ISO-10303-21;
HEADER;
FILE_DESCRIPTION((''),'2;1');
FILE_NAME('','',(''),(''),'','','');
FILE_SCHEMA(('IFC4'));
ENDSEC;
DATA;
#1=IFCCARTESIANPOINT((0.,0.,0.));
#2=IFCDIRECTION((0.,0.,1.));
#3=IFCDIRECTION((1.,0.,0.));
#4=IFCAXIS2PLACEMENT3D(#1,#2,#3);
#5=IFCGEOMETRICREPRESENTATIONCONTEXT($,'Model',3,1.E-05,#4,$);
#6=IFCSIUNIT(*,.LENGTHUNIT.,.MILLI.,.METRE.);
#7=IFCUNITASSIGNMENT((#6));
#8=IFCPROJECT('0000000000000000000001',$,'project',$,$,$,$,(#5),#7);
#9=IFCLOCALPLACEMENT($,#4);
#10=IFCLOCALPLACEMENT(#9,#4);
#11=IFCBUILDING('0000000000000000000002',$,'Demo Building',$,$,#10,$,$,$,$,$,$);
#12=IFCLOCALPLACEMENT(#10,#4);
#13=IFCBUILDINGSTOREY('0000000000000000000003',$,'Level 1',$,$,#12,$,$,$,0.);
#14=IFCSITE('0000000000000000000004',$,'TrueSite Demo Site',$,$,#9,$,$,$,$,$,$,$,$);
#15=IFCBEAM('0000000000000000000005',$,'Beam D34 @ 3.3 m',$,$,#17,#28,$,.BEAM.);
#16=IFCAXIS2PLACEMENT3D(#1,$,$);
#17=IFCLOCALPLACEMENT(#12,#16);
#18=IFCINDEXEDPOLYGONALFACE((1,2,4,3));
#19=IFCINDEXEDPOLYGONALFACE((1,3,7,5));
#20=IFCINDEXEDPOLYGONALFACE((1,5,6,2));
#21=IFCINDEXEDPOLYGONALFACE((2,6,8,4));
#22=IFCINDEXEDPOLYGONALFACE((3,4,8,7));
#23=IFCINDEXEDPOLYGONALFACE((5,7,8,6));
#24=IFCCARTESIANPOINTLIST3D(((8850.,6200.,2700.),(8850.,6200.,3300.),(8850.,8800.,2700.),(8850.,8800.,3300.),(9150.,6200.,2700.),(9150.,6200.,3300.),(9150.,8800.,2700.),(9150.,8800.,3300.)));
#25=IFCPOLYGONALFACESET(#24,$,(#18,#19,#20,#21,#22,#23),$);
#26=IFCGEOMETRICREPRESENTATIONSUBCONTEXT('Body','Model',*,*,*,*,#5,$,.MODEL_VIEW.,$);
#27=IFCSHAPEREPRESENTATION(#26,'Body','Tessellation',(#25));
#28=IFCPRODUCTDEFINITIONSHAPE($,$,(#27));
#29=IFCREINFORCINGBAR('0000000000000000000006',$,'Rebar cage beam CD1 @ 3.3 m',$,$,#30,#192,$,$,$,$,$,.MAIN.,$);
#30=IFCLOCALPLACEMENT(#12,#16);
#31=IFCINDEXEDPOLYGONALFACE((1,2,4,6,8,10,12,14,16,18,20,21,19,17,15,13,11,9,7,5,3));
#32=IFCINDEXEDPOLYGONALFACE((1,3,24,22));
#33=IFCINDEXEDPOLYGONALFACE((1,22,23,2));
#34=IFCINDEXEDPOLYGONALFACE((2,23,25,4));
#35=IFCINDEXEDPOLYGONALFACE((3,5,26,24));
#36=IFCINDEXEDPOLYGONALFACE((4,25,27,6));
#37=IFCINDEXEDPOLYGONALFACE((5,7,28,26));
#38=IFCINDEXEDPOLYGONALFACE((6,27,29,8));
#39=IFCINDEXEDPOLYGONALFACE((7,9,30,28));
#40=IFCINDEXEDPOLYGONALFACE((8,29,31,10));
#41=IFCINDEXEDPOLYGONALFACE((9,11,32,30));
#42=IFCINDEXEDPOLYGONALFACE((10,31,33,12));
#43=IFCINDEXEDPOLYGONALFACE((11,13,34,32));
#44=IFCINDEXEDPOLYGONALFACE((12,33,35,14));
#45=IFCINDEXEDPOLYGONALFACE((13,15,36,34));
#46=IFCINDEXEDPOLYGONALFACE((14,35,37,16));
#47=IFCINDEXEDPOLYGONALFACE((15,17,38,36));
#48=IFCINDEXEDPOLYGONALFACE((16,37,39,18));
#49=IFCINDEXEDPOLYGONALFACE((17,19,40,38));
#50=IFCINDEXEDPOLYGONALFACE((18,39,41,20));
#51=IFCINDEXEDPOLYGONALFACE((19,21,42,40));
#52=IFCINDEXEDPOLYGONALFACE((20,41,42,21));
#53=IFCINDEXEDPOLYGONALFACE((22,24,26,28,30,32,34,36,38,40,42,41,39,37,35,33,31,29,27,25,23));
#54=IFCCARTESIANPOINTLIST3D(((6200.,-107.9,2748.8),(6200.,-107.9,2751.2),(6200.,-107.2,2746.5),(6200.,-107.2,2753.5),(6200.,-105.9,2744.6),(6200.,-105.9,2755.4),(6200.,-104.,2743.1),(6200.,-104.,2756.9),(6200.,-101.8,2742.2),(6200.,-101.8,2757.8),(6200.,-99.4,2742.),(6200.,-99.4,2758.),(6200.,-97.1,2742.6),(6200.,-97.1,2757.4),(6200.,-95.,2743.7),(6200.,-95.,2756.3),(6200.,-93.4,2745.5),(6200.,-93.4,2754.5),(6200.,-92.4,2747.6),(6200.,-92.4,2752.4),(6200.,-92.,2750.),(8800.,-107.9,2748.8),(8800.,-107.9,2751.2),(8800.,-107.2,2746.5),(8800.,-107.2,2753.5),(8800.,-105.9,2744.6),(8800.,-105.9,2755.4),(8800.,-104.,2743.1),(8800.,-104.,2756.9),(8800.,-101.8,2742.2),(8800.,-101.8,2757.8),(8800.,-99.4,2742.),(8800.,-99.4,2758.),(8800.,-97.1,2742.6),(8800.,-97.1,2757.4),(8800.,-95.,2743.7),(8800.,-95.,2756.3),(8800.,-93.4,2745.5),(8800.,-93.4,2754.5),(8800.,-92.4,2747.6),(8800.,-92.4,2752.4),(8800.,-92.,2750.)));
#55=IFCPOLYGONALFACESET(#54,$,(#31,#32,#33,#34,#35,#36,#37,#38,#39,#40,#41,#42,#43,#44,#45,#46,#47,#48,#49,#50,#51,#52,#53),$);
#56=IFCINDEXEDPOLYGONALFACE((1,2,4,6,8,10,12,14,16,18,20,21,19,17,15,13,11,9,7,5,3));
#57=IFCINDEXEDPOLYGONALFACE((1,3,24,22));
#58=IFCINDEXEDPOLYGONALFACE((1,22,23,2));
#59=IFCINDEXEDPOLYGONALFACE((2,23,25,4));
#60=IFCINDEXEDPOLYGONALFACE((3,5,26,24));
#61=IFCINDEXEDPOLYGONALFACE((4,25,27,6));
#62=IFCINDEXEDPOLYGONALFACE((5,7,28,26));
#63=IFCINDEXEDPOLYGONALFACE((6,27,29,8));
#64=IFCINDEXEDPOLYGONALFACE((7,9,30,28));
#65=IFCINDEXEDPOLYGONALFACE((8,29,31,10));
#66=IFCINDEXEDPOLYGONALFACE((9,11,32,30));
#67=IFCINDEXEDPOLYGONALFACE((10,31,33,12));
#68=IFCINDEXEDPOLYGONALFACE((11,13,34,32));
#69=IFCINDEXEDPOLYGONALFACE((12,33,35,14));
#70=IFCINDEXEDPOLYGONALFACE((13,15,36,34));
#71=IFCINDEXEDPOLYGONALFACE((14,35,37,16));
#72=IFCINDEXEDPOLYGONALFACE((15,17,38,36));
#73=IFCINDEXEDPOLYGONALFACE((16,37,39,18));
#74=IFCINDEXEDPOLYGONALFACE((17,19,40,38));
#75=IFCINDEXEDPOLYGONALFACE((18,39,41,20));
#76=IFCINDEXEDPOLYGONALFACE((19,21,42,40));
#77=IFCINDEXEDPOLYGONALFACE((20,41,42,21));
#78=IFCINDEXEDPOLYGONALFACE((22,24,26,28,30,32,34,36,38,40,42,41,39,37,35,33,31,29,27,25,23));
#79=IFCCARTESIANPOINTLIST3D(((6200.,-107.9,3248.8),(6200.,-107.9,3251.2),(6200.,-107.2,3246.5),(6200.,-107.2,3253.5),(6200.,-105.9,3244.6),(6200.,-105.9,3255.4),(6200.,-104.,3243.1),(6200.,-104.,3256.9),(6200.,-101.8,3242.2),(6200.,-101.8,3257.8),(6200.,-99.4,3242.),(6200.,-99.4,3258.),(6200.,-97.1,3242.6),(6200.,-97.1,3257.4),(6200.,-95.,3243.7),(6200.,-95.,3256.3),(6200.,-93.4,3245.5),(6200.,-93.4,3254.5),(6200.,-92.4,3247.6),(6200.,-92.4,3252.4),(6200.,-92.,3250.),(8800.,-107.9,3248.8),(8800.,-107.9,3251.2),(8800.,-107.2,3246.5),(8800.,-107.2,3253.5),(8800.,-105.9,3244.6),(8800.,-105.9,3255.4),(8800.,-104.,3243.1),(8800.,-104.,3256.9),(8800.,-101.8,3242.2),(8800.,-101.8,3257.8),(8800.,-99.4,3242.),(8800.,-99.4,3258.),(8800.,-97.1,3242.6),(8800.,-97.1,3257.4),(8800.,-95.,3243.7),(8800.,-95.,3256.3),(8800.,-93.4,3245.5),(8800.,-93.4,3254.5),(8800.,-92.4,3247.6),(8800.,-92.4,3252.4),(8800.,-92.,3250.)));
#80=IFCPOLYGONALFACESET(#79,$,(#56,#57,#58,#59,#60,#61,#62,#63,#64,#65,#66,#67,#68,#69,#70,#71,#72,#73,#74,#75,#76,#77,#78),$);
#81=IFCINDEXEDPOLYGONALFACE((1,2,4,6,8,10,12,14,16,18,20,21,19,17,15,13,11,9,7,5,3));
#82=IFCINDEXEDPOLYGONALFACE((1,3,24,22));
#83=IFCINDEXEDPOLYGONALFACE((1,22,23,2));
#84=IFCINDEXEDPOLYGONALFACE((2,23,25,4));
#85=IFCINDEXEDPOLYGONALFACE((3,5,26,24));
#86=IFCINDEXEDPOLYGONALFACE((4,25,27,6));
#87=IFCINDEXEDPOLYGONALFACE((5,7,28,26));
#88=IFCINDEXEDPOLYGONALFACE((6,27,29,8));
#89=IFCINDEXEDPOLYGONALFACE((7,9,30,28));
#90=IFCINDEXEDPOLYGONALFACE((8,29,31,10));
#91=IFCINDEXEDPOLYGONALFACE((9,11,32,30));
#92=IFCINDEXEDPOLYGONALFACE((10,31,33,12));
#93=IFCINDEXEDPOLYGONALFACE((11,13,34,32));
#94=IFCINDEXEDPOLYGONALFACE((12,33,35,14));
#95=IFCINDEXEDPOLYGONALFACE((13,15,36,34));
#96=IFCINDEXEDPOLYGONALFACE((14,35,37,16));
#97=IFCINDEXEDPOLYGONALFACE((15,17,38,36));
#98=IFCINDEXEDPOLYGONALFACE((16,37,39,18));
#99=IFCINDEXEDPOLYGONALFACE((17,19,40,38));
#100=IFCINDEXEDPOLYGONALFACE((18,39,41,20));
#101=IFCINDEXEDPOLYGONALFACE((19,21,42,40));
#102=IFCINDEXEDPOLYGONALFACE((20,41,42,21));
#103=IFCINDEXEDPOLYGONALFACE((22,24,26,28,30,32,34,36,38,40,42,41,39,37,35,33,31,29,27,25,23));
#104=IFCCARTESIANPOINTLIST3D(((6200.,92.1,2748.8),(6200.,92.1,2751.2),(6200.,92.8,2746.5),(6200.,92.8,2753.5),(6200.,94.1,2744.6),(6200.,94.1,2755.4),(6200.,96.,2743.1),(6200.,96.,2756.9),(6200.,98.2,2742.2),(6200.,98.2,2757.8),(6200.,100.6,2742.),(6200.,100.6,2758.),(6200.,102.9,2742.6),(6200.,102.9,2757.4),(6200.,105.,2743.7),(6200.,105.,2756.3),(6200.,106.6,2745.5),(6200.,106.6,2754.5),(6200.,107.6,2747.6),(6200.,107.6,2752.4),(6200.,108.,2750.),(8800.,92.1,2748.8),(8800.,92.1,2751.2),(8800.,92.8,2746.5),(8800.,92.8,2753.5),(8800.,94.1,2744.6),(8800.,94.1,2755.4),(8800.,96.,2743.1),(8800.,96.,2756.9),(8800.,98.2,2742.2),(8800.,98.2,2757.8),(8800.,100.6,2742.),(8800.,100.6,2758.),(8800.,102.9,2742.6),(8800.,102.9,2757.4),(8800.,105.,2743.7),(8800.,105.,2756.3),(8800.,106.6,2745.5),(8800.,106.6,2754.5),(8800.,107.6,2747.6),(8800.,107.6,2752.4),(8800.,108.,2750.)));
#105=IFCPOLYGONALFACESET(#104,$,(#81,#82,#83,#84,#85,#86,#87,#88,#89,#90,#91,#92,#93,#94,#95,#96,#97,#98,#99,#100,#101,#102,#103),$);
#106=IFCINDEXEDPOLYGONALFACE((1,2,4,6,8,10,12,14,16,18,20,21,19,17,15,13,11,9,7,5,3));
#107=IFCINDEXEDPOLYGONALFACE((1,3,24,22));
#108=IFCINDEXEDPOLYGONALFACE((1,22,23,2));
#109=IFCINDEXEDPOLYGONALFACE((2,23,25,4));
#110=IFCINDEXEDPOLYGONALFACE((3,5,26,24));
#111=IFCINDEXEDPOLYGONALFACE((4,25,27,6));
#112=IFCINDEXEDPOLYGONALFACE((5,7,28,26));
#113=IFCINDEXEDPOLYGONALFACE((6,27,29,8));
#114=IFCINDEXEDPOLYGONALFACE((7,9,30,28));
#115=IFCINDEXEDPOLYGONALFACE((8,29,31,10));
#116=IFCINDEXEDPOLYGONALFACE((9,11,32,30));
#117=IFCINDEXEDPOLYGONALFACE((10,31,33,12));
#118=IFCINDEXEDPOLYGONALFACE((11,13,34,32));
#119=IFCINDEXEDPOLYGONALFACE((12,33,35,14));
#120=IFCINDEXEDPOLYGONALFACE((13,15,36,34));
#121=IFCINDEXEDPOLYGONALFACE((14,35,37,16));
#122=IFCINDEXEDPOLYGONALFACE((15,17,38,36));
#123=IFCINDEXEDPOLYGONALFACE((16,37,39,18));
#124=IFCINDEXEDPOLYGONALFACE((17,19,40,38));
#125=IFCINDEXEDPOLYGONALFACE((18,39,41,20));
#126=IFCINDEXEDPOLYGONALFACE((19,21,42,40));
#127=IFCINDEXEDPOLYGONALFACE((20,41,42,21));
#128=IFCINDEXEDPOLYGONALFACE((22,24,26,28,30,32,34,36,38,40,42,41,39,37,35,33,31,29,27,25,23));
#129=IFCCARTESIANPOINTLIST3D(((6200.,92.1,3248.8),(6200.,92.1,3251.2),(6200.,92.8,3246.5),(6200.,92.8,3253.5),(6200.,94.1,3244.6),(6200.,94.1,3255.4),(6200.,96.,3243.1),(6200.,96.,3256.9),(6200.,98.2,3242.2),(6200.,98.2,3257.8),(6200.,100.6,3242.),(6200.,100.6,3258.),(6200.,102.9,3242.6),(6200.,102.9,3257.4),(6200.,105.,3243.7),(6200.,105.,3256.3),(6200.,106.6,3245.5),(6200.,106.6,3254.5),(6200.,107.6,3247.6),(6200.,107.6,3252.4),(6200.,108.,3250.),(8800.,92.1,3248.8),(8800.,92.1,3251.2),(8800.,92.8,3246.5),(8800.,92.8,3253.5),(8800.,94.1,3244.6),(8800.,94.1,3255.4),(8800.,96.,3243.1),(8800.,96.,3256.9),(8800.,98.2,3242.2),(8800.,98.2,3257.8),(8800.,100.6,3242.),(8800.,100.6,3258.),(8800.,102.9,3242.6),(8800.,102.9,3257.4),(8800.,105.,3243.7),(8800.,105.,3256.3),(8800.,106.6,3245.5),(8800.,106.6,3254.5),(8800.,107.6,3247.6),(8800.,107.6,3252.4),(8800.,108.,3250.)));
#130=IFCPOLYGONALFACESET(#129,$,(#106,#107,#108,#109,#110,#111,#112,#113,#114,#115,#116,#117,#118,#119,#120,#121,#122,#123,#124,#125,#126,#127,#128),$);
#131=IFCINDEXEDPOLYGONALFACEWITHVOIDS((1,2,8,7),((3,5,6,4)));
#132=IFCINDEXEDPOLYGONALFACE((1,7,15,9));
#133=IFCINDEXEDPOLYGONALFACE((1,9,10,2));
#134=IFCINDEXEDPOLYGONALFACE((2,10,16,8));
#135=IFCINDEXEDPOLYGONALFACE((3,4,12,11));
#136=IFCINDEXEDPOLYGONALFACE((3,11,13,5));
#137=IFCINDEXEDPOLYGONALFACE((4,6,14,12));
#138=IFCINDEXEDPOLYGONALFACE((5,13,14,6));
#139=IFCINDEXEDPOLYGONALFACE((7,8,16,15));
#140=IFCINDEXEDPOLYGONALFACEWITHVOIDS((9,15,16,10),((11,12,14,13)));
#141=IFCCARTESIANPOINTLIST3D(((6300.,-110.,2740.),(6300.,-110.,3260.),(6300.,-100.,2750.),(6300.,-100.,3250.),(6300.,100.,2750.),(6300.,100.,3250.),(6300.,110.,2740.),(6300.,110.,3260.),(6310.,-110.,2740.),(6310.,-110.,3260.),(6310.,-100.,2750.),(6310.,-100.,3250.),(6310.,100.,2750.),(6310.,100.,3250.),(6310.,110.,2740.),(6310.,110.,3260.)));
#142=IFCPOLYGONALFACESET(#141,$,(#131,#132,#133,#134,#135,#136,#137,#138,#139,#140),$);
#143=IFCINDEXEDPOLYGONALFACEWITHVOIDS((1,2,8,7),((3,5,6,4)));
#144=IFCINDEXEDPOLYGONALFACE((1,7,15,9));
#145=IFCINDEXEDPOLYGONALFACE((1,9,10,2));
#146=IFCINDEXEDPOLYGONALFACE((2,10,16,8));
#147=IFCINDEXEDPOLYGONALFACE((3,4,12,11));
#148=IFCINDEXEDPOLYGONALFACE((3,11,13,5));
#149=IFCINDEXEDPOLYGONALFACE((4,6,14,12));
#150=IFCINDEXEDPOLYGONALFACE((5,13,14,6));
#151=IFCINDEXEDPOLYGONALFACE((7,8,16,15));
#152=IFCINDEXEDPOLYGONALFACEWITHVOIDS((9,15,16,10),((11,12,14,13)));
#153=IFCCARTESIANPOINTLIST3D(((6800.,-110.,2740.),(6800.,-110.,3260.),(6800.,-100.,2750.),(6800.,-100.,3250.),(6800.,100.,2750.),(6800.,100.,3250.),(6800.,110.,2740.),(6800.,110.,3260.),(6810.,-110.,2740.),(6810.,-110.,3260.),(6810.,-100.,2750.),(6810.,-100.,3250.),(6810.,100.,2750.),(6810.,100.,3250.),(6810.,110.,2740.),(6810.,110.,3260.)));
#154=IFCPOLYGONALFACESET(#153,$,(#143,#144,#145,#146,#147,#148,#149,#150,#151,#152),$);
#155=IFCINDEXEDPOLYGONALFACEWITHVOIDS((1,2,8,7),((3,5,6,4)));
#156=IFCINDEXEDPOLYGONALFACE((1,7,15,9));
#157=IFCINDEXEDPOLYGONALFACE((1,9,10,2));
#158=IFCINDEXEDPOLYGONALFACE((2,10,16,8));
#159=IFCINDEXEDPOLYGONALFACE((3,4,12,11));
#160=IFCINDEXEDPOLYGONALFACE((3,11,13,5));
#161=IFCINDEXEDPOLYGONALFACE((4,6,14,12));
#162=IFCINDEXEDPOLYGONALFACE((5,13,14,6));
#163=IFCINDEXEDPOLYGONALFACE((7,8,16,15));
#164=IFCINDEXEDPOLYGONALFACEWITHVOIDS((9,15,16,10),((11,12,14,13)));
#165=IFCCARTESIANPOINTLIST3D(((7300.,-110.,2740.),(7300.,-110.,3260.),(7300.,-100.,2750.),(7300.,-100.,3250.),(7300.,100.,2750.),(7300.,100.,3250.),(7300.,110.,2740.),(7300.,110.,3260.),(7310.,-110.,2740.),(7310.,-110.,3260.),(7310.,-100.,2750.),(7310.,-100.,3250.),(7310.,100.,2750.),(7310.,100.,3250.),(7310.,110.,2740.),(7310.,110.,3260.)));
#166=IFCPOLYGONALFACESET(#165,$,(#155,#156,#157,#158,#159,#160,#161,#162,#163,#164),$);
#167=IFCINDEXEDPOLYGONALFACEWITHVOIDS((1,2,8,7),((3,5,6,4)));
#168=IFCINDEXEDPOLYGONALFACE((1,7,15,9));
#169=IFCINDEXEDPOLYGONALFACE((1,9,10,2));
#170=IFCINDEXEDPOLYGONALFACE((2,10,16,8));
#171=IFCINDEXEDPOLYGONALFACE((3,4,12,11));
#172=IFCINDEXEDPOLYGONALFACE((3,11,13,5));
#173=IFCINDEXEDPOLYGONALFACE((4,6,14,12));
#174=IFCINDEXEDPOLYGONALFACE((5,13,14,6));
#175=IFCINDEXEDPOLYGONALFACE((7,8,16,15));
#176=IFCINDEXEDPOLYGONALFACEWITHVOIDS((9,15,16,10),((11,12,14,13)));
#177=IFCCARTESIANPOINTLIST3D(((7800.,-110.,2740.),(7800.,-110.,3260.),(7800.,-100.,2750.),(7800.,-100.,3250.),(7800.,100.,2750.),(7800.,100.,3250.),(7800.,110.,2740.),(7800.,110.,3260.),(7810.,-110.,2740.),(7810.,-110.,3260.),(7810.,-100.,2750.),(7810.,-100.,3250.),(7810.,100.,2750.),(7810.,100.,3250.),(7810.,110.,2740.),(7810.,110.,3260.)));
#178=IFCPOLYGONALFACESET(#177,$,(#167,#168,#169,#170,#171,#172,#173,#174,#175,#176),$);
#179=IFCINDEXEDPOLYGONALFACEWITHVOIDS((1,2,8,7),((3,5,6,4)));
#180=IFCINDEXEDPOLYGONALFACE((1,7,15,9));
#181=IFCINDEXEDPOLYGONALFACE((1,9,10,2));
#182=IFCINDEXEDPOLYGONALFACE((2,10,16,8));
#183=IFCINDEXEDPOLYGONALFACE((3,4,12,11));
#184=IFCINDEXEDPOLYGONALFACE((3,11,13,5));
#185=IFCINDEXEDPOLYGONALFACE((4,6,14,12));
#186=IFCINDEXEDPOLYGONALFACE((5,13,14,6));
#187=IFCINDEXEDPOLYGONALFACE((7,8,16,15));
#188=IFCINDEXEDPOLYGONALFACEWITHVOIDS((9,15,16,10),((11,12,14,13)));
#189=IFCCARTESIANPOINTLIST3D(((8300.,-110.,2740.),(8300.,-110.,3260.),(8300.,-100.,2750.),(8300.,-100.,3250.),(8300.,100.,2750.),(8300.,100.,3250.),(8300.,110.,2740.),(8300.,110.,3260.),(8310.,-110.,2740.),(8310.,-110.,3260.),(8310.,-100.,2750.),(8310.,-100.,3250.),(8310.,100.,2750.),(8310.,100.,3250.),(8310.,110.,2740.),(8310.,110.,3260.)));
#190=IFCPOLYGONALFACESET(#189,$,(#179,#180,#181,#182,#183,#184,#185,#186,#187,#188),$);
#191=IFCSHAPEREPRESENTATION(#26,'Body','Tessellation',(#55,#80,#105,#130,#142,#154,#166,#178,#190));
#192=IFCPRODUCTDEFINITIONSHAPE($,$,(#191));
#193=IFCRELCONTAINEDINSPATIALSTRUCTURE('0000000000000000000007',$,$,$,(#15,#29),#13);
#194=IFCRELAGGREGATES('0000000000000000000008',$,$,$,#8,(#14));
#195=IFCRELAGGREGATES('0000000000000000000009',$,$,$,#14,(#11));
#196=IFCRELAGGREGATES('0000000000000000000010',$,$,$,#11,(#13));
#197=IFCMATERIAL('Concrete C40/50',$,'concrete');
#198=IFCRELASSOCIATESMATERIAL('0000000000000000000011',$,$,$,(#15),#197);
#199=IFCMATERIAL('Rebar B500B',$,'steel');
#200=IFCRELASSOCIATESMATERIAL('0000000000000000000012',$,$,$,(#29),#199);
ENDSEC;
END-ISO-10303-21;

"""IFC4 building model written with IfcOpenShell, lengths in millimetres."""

from ifc_helpers import new_model, si_unit, frame, origin_with_axes, place, context, subcontext, project, spatial, rectangle, hollow_rectangle, circle, extrude, material, element, save


model = new_model("IFC4")

# Units and contexts
model_context = context("Model", 3, precision=1e-05, world=origin_with_axes())
body_context = subcontext(model_context, "Body", "Model", "MODEL_VIEW")
ifc_project = project(units=[si_unit("LENGTHUNIT", "METRE", prefix="MILLI")], contexts=[model_context])

# Site, building, storey
site_placement = place(None, origin_with_axes())
site = spatial("IfcSite", under=ifc_project, at=site_placement, Name="TrueSite Demo Site")
building_placement = place(site_placement, origin_with_axes())
building = spatial("IfcBuilding", under=site, at=building_placement, Name="Demo Building")
storey_placement = place(building_placement, origin_with_axes())
storey = spatial("IfcBuildingStorey", under=building, at=storey_placement, Name="Level 1", Elevation=0.0)

# Shared definitions
ifc_material_1 = material(Name="Concrete C40/50", Category="concrete")

# Beam
for number, where, z_axis, x_axis, name in (
    (1, (9000.0, 6200.0, 3000.0), (0.0, 1.0, 0.0), (1.0, 0.0, 0.0), "Beam D34 @ 3.3 m"),
):
    element("IfcBeam", number, at=place(storey_placement, frame(where, z_axis=z_axis, x_axis=x_axis)), inside=storey, material=ifc_material_1, Name=name, PredefinedType="BEAM", context=body_context, shape_type="SweptSolid", body=[
        extrude(rectangle(XDim=300.0, YDim=600.0), origin_with_axes(), (0.0, 0.0, 1.0), 2600.0),
    ])

# Reinforcing bar
ifc_material_2 = material(Name="Rebar B500B", Category="steel")
for number, where, z_axis, x_axis, name in (
    (2, (6200.0, 0.0, 3000.0), (1.0, 0.0, 0.0), (0.0, 1.0, 0.0), "Rebar cage beam CD1 @ 3.3 m"),
):
    element("IfcReinforcingBar", number, at=place(storey_placement, frame(where, z_axis=z_axis, x_axis=x_axis)), inside=storey, material=ifc_material_2, Name=name, PredefinedType="MAIN", context=body_context, shape_type="SweptSolid", body=[
        extrude(circle(Radius=8.0), frame((-100.0, -250.0, 0.0)), (0.0, 0.0, 1.0), 2600.0),
        extrude(circle(Radius=8.0), frame((-100.0, 250.0, 0.0)), (0.0, 0.0, 1.0), 2600.0),
        extrude(circle(Radius=8.0), frame((100.0, -250.0, 0.0)), (0.0, 0.0, 1.0), 2600.0),
        extrude(circle(Radius=8.0), frame((100.0, 250.0, 0.0)), (0.0, 0.0, 1.0), 2600.0),
        extrude(hollow_rectangle(XDim=220.0, YDim=520.0, WallThickness=10.0), frame((0.0, 0.0, 100.0)), (0.0, 0.0, 1.0), 10.0),
        extrude(hollow_rectangle(XDim=220.0, YDim=520.0, WallThickness=10.0), frame((0.0, 0.0, 600.0)), (0.0, 0.0, 1.0), 10.0),
        extrude(hollow_rectangle(XDim=220.0, YDim=520.0, WallThickness=10.0), frame((0.0, 0.0, 1100.0)), (0.0, 0.0, 1.0), 10.0),
        extrude(hollow_rectangle(XDim=220.0, YDim=520.0, WallThickness=10.0), frame((0.0, 0.0, 1600.0)), (0.0, 0.0, 1.0), 10.0),
        extrude(hollow_rectangle(XDim=220.0, YDim=520.0, WallThickness=10.0), frame((0.0, 0.0, 2100.0)), (0.0, 0.0, 1.0), 10.0),
    ])

save(model, "model.ifc")
